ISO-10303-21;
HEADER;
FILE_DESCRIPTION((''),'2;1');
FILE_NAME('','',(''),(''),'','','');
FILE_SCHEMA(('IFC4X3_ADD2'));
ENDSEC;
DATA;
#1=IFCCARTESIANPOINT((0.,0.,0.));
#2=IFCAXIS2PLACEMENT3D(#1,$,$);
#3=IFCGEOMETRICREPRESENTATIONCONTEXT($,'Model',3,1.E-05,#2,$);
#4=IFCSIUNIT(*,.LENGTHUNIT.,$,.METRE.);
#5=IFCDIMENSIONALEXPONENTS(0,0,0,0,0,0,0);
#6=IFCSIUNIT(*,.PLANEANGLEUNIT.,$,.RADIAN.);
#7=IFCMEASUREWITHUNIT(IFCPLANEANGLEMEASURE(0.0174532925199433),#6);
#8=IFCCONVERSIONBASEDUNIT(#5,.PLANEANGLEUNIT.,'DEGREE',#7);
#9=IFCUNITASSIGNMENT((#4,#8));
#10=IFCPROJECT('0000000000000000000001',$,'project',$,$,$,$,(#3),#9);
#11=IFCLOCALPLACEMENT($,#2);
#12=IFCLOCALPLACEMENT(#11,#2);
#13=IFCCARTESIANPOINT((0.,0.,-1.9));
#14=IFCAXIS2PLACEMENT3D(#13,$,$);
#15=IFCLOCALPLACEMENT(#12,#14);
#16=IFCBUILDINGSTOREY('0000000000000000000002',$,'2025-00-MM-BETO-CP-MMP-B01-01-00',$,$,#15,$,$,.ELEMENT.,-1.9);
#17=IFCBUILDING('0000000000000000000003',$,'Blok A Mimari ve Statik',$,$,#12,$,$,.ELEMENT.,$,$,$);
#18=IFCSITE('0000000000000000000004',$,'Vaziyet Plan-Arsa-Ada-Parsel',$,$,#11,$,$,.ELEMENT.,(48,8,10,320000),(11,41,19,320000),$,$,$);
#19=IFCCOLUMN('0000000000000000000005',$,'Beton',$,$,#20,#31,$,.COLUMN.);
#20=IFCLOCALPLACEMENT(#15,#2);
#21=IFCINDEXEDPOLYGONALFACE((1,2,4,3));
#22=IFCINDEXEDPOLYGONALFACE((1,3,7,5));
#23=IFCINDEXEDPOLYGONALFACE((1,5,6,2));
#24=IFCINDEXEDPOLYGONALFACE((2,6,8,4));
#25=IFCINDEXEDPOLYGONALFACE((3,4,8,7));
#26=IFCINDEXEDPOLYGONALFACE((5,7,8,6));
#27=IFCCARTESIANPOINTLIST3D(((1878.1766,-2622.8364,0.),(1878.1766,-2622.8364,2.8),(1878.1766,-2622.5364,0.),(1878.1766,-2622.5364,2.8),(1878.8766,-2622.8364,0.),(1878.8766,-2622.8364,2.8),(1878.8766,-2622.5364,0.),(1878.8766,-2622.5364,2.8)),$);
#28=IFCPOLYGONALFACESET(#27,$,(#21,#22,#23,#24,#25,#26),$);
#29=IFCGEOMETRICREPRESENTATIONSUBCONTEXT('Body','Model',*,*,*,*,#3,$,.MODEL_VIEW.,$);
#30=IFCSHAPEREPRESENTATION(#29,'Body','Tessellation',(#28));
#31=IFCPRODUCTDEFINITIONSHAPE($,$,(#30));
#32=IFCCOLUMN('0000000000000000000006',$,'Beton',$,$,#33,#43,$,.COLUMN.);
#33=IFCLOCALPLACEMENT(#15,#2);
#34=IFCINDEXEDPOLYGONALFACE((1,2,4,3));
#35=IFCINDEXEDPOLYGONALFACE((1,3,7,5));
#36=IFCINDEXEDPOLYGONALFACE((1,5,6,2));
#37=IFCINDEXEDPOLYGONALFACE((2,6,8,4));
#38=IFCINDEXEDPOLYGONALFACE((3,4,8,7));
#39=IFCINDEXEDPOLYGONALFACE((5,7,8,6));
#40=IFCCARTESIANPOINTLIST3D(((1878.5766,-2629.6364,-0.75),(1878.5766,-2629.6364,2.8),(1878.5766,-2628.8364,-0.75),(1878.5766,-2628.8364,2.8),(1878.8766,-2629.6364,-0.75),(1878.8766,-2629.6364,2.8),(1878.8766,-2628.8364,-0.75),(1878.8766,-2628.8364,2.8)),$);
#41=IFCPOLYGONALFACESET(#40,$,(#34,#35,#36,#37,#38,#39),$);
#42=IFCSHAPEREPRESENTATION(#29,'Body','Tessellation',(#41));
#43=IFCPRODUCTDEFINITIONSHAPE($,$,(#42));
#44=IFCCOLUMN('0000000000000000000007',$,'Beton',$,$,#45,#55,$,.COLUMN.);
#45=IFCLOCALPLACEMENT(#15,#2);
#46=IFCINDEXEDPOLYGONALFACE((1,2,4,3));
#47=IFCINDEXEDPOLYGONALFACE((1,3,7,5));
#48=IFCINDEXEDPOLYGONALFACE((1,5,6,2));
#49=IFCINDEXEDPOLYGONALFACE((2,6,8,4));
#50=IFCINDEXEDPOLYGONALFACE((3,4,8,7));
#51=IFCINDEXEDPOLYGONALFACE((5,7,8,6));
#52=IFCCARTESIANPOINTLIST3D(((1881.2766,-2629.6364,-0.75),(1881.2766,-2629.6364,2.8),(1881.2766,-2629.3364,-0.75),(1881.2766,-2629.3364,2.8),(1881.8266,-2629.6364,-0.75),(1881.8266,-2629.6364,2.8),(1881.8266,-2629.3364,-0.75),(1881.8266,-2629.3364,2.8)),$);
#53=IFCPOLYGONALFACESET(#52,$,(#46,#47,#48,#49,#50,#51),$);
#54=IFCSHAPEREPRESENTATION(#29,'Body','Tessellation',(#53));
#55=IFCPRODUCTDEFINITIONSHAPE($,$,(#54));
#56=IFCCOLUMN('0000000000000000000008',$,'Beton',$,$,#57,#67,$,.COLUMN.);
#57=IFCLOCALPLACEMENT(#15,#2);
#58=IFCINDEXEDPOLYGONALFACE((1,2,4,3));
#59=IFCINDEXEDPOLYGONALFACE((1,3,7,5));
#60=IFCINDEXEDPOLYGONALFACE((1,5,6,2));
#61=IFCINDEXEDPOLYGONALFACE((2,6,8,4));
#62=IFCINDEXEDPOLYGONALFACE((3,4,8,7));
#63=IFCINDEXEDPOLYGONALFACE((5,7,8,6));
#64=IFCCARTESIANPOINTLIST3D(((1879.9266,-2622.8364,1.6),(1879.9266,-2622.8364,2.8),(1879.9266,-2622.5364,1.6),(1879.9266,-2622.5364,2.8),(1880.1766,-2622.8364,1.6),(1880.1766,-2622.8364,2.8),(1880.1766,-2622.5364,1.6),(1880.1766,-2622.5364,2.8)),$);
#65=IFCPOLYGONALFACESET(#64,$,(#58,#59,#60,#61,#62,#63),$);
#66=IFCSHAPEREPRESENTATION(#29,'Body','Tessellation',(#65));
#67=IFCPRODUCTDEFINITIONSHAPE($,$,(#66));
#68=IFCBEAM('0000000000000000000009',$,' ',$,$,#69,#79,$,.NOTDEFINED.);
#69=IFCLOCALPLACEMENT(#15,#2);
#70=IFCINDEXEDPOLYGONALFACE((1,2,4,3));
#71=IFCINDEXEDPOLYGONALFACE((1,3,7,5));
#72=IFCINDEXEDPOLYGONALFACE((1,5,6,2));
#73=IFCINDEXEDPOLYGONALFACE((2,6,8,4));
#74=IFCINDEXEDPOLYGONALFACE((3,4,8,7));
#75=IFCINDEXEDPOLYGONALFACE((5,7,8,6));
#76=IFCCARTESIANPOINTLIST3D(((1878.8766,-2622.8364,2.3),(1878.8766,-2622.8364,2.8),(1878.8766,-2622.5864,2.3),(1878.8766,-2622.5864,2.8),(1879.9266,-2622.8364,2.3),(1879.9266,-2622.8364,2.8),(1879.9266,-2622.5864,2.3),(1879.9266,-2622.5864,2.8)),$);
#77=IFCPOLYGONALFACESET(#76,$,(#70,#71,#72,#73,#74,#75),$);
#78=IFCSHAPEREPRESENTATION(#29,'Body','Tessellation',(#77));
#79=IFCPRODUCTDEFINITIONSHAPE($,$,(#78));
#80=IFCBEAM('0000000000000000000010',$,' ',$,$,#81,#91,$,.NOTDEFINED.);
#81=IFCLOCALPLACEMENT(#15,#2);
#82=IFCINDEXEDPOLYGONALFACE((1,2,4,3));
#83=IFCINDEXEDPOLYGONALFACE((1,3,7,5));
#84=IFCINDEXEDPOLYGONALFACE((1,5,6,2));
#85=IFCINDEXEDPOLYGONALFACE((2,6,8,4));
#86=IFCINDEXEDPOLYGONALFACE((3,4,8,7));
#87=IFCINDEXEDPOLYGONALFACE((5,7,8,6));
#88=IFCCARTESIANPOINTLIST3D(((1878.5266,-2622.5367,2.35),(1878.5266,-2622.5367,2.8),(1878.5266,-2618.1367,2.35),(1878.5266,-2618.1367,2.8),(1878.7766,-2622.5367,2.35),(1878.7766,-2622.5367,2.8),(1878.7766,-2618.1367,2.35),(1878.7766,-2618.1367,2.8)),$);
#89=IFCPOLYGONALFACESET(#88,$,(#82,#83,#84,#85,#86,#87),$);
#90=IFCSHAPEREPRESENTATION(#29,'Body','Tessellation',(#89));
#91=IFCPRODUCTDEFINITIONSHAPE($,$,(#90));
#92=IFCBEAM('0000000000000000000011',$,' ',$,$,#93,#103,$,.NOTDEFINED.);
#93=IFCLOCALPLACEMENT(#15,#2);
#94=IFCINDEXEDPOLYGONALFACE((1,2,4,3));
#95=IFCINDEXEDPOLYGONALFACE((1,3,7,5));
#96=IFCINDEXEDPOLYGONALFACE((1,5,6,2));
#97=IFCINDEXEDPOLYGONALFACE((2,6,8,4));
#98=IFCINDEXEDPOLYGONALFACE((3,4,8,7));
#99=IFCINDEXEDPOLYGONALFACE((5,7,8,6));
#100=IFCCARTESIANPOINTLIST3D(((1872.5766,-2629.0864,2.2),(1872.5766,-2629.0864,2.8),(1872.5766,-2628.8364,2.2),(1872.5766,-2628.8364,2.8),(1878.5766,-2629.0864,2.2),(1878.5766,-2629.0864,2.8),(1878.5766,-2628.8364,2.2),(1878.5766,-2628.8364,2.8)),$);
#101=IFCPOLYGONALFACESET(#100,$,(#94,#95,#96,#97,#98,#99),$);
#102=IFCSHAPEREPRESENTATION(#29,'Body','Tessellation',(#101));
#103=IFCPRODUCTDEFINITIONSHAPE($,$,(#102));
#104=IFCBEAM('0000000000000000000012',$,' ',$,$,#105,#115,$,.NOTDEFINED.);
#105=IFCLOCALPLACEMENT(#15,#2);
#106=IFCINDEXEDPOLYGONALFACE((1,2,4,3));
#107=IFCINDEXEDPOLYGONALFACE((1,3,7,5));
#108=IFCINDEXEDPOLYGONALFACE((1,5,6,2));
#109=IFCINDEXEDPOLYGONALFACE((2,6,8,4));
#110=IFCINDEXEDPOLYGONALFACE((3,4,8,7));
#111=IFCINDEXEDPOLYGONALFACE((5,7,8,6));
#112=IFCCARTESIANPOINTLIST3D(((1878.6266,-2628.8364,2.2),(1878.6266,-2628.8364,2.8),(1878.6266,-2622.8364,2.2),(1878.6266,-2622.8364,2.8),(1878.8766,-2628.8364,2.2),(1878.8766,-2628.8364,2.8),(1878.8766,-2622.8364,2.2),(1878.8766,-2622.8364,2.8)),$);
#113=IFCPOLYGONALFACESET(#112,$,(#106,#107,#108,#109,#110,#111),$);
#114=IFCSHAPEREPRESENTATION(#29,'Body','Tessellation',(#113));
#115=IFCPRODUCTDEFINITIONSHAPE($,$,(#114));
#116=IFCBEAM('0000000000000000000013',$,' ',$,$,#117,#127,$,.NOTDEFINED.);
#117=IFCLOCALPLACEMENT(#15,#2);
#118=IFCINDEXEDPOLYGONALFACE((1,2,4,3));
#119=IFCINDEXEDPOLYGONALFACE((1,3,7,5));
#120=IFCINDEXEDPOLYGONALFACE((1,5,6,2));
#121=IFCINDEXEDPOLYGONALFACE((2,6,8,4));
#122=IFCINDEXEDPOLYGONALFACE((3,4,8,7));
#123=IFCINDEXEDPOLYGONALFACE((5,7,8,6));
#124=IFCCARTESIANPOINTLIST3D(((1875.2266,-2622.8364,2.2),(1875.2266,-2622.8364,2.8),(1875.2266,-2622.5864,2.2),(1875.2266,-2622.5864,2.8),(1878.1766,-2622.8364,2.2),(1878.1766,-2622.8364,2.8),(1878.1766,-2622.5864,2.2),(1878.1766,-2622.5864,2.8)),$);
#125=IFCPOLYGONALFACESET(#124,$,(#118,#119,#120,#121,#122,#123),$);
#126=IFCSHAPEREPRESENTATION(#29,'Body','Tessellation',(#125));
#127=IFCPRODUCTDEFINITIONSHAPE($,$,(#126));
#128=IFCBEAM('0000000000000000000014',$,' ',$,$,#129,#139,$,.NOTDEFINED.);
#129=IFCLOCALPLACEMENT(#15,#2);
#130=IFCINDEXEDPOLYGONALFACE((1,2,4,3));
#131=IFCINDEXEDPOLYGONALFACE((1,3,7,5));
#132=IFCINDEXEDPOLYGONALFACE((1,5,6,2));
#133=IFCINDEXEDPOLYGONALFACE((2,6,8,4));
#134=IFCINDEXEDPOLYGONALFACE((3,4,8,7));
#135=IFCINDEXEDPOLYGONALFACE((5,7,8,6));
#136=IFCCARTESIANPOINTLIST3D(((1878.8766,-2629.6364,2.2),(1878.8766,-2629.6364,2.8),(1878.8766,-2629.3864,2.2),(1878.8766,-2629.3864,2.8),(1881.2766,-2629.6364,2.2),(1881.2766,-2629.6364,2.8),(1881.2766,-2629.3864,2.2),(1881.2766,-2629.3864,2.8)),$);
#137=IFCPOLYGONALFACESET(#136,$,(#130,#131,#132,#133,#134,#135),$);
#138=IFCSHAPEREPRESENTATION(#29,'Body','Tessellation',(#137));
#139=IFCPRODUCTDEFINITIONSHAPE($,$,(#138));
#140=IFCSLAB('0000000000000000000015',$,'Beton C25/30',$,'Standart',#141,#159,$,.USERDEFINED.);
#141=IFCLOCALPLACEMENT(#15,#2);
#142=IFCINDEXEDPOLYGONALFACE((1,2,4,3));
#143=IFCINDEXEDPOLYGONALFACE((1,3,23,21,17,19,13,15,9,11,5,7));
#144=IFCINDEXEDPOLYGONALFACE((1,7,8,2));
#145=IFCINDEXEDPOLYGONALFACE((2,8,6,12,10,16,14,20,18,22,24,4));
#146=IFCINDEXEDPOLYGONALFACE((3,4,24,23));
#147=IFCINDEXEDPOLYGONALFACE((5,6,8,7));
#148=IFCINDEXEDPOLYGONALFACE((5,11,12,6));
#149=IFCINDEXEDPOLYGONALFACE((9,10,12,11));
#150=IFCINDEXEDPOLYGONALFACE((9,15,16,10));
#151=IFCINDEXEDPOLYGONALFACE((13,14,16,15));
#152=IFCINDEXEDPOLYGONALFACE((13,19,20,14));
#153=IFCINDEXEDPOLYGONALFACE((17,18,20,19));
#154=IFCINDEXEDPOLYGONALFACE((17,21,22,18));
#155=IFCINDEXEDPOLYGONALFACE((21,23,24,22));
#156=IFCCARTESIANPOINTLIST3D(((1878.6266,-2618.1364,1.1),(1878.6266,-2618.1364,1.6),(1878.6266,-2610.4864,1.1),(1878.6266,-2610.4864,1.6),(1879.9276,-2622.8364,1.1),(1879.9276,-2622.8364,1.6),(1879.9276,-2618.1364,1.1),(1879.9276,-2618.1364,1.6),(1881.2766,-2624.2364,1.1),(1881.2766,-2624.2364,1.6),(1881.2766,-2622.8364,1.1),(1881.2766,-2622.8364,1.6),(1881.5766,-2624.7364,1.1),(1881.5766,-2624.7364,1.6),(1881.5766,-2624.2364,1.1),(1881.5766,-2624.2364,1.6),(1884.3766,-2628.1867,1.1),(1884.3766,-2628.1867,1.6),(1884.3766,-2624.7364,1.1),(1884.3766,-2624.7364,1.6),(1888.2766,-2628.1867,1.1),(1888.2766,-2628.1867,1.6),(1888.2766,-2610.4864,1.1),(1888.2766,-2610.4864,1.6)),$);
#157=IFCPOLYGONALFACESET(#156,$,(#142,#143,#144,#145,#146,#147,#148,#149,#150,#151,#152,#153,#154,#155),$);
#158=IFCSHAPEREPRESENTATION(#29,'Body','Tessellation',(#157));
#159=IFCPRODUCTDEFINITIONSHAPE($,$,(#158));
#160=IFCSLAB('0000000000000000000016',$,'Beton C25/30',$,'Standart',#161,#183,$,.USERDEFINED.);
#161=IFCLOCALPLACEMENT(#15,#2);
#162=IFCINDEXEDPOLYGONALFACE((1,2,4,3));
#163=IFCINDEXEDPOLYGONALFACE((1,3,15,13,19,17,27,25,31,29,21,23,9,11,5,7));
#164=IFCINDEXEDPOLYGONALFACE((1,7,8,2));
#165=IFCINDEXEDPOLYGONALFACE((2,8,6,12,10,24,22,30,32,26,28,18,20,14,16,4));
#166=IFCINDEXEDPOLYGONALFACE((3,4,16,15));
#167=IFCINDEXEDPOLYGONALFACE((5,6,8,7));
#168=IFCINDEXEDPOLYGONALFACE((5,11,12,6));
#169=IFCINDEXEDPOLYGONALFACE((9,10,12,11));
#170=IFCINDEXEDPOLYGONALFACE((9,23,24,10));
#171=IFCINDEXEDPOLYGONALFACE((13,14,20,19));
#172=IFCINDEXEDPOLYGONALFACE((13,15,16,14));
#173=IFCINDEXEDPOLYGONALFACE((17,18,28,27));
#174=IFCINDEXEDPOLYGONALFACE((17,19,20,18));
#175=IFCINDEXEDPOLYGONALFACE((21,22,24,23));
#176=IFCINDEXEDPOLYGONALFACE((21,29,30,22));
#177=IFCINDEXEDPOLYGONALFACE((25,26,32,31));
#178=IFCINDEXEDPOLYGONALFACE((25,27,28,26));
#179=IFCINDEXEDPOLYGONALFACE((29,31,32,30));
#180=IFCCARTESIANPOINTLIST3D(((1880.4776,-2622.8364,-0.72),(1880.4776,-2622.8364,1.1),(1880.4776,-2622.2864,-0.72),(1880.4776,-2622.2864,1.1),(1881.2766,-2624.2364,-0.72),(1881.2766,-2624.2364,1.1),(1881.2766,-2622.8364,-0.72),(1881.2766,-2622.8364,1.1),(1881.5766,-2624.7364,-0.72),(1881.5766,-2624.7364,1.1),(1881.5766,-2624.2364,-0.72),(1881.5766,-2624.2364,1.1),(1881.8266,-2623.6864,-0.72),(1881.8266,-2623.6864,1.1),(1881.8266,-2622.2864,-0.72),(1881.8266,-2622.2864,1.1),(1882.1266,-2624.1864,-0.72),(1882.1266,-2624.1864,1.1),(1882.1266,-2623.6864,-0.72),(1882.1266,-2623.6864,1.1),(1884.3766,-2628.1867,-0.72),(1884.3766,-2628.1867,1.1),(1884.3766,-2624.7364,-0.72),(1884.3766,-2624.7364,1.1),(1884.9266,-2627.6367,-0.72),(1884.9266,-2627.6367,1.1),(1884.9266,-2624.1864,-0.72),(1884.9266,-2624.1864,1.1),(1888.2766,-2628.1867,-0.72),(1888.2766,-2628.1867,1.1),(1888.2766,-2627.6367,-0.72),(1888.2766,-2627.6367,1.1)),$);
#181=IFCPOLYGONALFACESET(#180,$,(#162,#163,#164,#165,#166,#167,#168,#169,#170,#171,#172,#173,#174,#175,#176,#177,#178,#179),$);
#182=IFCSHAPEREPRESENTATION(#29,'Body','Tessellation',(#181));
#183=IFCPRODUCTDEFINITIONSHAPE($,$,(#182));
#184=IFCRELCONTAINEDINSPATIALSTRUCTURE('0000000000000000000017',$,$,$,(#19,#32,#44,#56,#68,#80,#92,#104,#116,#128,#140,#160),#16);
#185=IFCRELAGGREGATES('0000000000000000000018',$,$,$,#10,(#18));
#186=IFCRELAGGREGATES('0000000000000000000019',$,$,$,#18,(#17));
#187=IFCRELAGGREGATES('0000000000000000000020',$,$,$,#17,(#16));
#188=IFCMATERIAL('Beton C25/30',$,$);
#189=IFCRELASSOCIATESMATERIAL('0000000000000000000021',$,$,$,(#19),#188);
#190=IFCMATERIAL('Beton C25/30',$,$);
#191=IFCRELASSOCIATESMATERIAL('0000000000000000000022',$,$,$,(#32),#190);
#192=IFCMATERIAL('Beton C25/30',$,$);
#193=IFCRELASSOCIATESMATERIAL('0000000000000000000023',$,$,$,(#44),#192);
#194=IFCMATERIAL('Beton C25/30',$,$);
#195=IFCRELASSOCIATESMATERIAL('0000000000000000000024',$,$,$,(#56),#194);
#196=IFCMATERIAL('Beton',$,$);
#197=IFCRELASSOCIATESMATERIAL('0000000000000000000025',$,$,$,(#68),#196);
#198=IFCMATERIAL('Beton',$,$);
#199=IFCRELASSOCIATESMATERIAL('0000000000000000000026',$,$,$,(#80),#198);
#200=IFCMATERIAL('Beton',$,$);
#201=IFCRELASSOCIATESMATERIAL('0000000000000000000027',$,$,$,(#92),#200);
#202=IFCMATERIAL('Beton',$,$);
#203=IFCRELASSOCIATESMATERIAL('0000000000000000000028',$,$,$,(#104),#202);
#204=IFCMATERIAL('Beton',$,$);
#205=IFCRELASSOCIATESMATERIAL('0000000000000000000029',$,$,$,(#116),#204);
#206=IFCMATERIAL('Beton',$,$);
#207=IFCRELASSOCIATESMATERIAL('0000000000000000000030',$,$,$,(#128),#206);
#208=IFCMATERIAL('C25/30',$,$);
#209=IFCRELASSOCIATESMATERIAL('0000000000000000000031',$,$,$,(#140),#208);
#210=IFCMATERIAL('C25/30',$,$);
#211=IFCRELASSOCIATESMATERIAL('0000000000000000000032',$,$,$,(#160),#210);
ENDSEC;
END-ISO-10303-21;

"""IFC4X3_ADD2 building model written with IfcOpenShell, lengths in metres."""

from ifc_helpers import new_model, entity, si_unit, converted_unit, frame, frame_2d, origin, origin_with_axes, place, context, subcontext, project, spatial, polyline, rectangle, outline, extrude, material, element, save


model = new_model("IFC4X3_ADD2")

# Units and contexts
model_context = context("Model", 3, precision=1e-05, world=origin())
body_context = subcontext(model_context, "Body", "Model", "MODEL_VIEW")
ifc_project = project(units=[si_unit("LENGTHUNIT", "METRE"), converted_unit("PLANEANGLEUNIT", "DEGREE", entity("IfcPlaneAngleMeasure", 0.0174532925199433), si_unit("PLANEANGLEUNIT", "RADIAN"), dimensions=[0, 0, 0, 0, 0, 0, 0])], contexts=[model_context])

# Site, building, storey
site_placement = place(None, origin())
site = spatial("IfcSite", under=ifc_project, at=site_placement, Name="Vaziyet Plan-Arsa-Ada-Parsel", CompositionType="ELEMENT", RefLatitude=(48, 8, 10, 320000), RefLongitude=(11, 41, 19, 320000))
building_placement = place(site_placement, origin())
building = spatial("IfcBuilding", under=site, at=building_placement, Name="Blok A Mimari ve Statik", CompositionType="ELEMENT")
storey_placement = place(building_placement, frame((0.0, 0.0, -1.9)))
storey = spatial("IfcBuildingStorey", under=building, at=storey_placement, Name="2025-00-MM-BETO-CP-MMP-B01-01-00", CompositionType="ELEMENT", Elevation=-1.9)

# Columns
ifc_material_1 = material(Name="Beton C25/30")
column_1_placement = place(storey_placement, frame((1878.1766, -2622.8364, 0.0)))
element("IfcColumn", 1, at=column_1_placement, inside=storey, material=ifc_material_1, Name="Beton", PredefinedType="COLUMN", context=body_context, shape_type="SweptSolid", body=[
    extrude(outline(polyline([(0.0, 0.0), (0.7, 0.0), (0.7, 0.3), (0.0, 0.3), (0.0, 0.0)])), origin_with_axes(), (0.0, 0.0, 1.0), 2.8),
])
ifc_material_2 = material(Name="Beton C25/30")
column_2_placement = place(storey_placement, frame((1878.5766, -2629.6364, -0.75)))
element("IfcColumn", 2, at=column_2_placement, inside=storey, material=ifc_material_2, Name="Beton", PredefinedType="COLUMN", context=body_context, shape_type="SweptSolid", body=[
    extrude(outline(polyline([(0.0, 0.0), (0.3, 0.0), (0.3, 0.8), (0.0, 0.8), (0.0, 0.0)])), origin_with_axes(), (0.0, 0.0, 1.0), 3.55),
])
ifc_material_3 = material(Name="Beton C25/30")
column_3_placement = place(storey_placement, frame((1881.2766, -2629.6364, -0.75)))
element("IfcColumn", 3, at=column_3_placement, inside=storey, material=ifc_material_3, Name="Beton", PredefinedType="COLUMN", context=body_context, shape_type="SweptSolid", body=[
    extrude(outline(polyline([(0.0, 0.3), (0.0, 0.0), (0.55, 0.0), (0.55, 0.3), (0.0, 0.3)])), origin_with_axes(), (0.0, 0.0, 1.0), 3.55),
])
ifc_material_4 = material(Name="Beton C25/30")
column_4_placement = place(storey_placement, frame((1879.9266, -2622.8364, 1.6)))
element("IfcColumn", 4, at=column_4_placement, inside=storey, material=ifc_material_4, Name="Beton", PredefinedType="COLUMN", context=body_context, shape_type="SweptSolid", body=[
    extrude(outline(polyline([(0.0, 0.3), (0.0, 0.0), (0.25, 0.0), (0.25, 0.3), (0.0, 0.3)])), origin_with_axes(), (0.0, 0.0, 1.0), 1.2),
])

# Beams
ifc_material_5 = material(Name="Beton")
beam_1_placement = place(storey_placement, frame((1878.8766, -2622.8364, 2.3)))
element("IfcBeam", 5, at=beam_1_placement, inside=storey, material=ifc_material_5, Name=" ", PredefinedType="NOTDEFINED", context=body_context, shape_type="SweptSolid", body=[
    extrude(rectangle(XDim=0.25, YDim=0.5, at=frame_2d((0.125, 0.25), x_axis=(1.0, 0.0))), frame((0.0, 0.0, 0.0), z_axis=(1.0, 0.0, 0.0), x_axis=(0.0, 1.0, 0.0)), (0.0, 0.0, 1.0), 1.05),
])
ifc_material_6 = material(Name="Beton")
beam_2_placement = place(storey_placement, frame((1878.7766, -2622.5367, 2.35), z_axis=(0.0, 0.0, 1.0), x_axis=(0.0, 1.0, 0.0)))
element("IfcBeam", 6, at=beam_2_placement, inside=storey, material=ifc_material_6, Name=" ", PredefinedType="NOTDEFINED", context=body_context, shape_type="SweptSolid", body=[
    extrude(rectangle(XDim=0.25, YDim=0.45, at=frame_2d((0.125, 0.225), x_axis=(1.0, 0.0))), frame((0.0, 0.0, 0.0), z_axis=(1.0, 0.0, 0.0), x_axis=(0.0, 1.0, 0.0)), (0.0, 0.0, 1.0), 4.4),
])
ifc_material_7 = material(Name="Beton")
beam_3_placement = place(storey_placement, frame((1878.5766, -2628.8364, 2.2), z_axis=(0.0, 0.0, 1.0), x_axis=(-1.0, 0.0, 0.0)))
element("IfcBeam", 7, at=beam_3_placement, inside=storey, material=ifc_material_7, Name=" ", PredefinedType="NOTDEFINED", context=body_context, shape_type="SweptSolid", body=[
    extrude(rectangle(XDim=0.25, YDim=0.6, at=frame_2d((0.125, 0.3), x_axis=(1.0, 0.0))), frame((0.0, 0.0, 0.0), z_axis=(1.0, 0.0, 0.0), x_axis=(0.0, 1.0, 0.0)), (0.0, 0.0, 1.0), 6.0),
])
ifc_material_8 = material(Name="Beton")
beam_4_placement = place(storey_placement, frame((1878.8766, -2628.8364, 2.2), z_axis=(0.0, 0.0, 1.0), x_axis=(0.0, 1.0, 0.0)))
element("IfcBeam", 8, at=beam_4_placement, inside=storey, material=ifc_material_8, Name=" ", PredefinedType="NOTDEFINED", context=body_context, shape_type="SweptSolid", body=[
    extrude(rectangle(XDim=0.25, YDim=0.6, at=frame_2d((0.125, 0.3), x_axis=(1.0, 0.0))), frame((0.0, 0.0, 0.0), z_axis=(1.0, 0.0, 0.0), x_axis=(0.0, 1.0, 0.0)), (0.0, 0.0, 1.0), 6.0),
])
ifc_material_9 = material(Name="Beton")
beam_5_placement = place(storey_placement, frame((1875.2266, -2622.8364, 2.2)))
element("IfcBeam", 9, at=beam_5_placement, inside=storey, material=ifc_material_9, Name=" ", PredefinedType="NOTDEFINED", context=body_context, shape_type="SweptSolid", body=[
    extrude(rectangle(XDim=0.25, YDim=0.6, at=frame_2d((0.125, 0.3), x_axis=(1.0, 0.0))), frame((0.0, 0.0, 0.0), z_axis=(1.0, 0.0, 0.0), x_axis=(0.0, 1.0, 0.0)), (0.0, 0.0, 1.0), 2.95),
])
ifc_material_10 = material(Name="Beton")
beam_6_placement = place(storey_placement, frame((1878.8766, -2629.6364, 2.2)))
element("IfcBeam", 10, at=beam_6_placement, inside=storey, material=ifc_material_10, Name=" ", PredefinedType="NOTDEFINED", context=body_context, shape_type="SweptSolid", body=[
    extrude(rectangle(XDim=0.25, YDim=0.6, at=frame_2d((0.125, 0.3), x_axis=(1.0, 0.0))), frame((0.0, 0.0, 0.0), z_axis=(1.0, 0.0, 0.0), x_axis=(0.0, 1.0, 0.0)), (0.0, 0.0, 1.0), 2.4),
])

# Slabs
ifc_material_11 = material(Name="C25/30")
slab_1_placement = place(storey_placement, frame((1878.6266, -2628.1867, 1.1)))
element("IfcSlab", 11, at=slab_1_placement, inside=storey, material=ifc_material_11, Name="Beton C25/30", ObjectType="Standart", PredefinedType="USERDEFINED", context=body_context, shape_type="SweptSolid", body=[
    extrude(outline(polyline([(0.0, 10.0503), (1.301, 10.0503), (1.301, 5.3503), (2.65, 5.3503), (2.65, 3.9503), (2.95, 3.9503), (2.95, 3.4503), (5.75, 3.4503), (5.75, 0.0), (9.65, 0.0), (9.65, 17.7003), (0.0, 17.7003), (0.0, 10.0503)])), origin_with_axes(), (0.0, 0.0, 1.0), 0.5),
])
ifc_material_12 = material(Name="C25/30")
slab_2_placement = place(storey_placement, frame((1880.4776, -2628.1867, -0.72)))
element("IfcSlab", 12, at=slab_2_placement, inside=storey, material=ifc_material_12, Name="Beton C25/30", ObjectType="Standart", PredefinedType="USERDEFINED", context=body_context, shape_type="SweptSolid", body=[
    extrude(outline(polyline([(1.649, 4.5003), (1.349, 4.5003), (1.349, 5.9003), (0.0, 5.9003), (0.0, 5.3503), (0.799, 5.3503), (0.799, 3.9503), (1.099, 3.9503), (1.099, 3.4503), (3.899, 3.4503), (3.899, 0.0), (7.799, 0.0), (7.799, 0.55), (4.449, 0.55), (4.449, 4.0003), (1.649, 4.0003), (1.649, 4.5003)])), origin_with_axes(), (0.0, 0.0, 1.0), 1.82),
])

save(model, "model.ifc")
